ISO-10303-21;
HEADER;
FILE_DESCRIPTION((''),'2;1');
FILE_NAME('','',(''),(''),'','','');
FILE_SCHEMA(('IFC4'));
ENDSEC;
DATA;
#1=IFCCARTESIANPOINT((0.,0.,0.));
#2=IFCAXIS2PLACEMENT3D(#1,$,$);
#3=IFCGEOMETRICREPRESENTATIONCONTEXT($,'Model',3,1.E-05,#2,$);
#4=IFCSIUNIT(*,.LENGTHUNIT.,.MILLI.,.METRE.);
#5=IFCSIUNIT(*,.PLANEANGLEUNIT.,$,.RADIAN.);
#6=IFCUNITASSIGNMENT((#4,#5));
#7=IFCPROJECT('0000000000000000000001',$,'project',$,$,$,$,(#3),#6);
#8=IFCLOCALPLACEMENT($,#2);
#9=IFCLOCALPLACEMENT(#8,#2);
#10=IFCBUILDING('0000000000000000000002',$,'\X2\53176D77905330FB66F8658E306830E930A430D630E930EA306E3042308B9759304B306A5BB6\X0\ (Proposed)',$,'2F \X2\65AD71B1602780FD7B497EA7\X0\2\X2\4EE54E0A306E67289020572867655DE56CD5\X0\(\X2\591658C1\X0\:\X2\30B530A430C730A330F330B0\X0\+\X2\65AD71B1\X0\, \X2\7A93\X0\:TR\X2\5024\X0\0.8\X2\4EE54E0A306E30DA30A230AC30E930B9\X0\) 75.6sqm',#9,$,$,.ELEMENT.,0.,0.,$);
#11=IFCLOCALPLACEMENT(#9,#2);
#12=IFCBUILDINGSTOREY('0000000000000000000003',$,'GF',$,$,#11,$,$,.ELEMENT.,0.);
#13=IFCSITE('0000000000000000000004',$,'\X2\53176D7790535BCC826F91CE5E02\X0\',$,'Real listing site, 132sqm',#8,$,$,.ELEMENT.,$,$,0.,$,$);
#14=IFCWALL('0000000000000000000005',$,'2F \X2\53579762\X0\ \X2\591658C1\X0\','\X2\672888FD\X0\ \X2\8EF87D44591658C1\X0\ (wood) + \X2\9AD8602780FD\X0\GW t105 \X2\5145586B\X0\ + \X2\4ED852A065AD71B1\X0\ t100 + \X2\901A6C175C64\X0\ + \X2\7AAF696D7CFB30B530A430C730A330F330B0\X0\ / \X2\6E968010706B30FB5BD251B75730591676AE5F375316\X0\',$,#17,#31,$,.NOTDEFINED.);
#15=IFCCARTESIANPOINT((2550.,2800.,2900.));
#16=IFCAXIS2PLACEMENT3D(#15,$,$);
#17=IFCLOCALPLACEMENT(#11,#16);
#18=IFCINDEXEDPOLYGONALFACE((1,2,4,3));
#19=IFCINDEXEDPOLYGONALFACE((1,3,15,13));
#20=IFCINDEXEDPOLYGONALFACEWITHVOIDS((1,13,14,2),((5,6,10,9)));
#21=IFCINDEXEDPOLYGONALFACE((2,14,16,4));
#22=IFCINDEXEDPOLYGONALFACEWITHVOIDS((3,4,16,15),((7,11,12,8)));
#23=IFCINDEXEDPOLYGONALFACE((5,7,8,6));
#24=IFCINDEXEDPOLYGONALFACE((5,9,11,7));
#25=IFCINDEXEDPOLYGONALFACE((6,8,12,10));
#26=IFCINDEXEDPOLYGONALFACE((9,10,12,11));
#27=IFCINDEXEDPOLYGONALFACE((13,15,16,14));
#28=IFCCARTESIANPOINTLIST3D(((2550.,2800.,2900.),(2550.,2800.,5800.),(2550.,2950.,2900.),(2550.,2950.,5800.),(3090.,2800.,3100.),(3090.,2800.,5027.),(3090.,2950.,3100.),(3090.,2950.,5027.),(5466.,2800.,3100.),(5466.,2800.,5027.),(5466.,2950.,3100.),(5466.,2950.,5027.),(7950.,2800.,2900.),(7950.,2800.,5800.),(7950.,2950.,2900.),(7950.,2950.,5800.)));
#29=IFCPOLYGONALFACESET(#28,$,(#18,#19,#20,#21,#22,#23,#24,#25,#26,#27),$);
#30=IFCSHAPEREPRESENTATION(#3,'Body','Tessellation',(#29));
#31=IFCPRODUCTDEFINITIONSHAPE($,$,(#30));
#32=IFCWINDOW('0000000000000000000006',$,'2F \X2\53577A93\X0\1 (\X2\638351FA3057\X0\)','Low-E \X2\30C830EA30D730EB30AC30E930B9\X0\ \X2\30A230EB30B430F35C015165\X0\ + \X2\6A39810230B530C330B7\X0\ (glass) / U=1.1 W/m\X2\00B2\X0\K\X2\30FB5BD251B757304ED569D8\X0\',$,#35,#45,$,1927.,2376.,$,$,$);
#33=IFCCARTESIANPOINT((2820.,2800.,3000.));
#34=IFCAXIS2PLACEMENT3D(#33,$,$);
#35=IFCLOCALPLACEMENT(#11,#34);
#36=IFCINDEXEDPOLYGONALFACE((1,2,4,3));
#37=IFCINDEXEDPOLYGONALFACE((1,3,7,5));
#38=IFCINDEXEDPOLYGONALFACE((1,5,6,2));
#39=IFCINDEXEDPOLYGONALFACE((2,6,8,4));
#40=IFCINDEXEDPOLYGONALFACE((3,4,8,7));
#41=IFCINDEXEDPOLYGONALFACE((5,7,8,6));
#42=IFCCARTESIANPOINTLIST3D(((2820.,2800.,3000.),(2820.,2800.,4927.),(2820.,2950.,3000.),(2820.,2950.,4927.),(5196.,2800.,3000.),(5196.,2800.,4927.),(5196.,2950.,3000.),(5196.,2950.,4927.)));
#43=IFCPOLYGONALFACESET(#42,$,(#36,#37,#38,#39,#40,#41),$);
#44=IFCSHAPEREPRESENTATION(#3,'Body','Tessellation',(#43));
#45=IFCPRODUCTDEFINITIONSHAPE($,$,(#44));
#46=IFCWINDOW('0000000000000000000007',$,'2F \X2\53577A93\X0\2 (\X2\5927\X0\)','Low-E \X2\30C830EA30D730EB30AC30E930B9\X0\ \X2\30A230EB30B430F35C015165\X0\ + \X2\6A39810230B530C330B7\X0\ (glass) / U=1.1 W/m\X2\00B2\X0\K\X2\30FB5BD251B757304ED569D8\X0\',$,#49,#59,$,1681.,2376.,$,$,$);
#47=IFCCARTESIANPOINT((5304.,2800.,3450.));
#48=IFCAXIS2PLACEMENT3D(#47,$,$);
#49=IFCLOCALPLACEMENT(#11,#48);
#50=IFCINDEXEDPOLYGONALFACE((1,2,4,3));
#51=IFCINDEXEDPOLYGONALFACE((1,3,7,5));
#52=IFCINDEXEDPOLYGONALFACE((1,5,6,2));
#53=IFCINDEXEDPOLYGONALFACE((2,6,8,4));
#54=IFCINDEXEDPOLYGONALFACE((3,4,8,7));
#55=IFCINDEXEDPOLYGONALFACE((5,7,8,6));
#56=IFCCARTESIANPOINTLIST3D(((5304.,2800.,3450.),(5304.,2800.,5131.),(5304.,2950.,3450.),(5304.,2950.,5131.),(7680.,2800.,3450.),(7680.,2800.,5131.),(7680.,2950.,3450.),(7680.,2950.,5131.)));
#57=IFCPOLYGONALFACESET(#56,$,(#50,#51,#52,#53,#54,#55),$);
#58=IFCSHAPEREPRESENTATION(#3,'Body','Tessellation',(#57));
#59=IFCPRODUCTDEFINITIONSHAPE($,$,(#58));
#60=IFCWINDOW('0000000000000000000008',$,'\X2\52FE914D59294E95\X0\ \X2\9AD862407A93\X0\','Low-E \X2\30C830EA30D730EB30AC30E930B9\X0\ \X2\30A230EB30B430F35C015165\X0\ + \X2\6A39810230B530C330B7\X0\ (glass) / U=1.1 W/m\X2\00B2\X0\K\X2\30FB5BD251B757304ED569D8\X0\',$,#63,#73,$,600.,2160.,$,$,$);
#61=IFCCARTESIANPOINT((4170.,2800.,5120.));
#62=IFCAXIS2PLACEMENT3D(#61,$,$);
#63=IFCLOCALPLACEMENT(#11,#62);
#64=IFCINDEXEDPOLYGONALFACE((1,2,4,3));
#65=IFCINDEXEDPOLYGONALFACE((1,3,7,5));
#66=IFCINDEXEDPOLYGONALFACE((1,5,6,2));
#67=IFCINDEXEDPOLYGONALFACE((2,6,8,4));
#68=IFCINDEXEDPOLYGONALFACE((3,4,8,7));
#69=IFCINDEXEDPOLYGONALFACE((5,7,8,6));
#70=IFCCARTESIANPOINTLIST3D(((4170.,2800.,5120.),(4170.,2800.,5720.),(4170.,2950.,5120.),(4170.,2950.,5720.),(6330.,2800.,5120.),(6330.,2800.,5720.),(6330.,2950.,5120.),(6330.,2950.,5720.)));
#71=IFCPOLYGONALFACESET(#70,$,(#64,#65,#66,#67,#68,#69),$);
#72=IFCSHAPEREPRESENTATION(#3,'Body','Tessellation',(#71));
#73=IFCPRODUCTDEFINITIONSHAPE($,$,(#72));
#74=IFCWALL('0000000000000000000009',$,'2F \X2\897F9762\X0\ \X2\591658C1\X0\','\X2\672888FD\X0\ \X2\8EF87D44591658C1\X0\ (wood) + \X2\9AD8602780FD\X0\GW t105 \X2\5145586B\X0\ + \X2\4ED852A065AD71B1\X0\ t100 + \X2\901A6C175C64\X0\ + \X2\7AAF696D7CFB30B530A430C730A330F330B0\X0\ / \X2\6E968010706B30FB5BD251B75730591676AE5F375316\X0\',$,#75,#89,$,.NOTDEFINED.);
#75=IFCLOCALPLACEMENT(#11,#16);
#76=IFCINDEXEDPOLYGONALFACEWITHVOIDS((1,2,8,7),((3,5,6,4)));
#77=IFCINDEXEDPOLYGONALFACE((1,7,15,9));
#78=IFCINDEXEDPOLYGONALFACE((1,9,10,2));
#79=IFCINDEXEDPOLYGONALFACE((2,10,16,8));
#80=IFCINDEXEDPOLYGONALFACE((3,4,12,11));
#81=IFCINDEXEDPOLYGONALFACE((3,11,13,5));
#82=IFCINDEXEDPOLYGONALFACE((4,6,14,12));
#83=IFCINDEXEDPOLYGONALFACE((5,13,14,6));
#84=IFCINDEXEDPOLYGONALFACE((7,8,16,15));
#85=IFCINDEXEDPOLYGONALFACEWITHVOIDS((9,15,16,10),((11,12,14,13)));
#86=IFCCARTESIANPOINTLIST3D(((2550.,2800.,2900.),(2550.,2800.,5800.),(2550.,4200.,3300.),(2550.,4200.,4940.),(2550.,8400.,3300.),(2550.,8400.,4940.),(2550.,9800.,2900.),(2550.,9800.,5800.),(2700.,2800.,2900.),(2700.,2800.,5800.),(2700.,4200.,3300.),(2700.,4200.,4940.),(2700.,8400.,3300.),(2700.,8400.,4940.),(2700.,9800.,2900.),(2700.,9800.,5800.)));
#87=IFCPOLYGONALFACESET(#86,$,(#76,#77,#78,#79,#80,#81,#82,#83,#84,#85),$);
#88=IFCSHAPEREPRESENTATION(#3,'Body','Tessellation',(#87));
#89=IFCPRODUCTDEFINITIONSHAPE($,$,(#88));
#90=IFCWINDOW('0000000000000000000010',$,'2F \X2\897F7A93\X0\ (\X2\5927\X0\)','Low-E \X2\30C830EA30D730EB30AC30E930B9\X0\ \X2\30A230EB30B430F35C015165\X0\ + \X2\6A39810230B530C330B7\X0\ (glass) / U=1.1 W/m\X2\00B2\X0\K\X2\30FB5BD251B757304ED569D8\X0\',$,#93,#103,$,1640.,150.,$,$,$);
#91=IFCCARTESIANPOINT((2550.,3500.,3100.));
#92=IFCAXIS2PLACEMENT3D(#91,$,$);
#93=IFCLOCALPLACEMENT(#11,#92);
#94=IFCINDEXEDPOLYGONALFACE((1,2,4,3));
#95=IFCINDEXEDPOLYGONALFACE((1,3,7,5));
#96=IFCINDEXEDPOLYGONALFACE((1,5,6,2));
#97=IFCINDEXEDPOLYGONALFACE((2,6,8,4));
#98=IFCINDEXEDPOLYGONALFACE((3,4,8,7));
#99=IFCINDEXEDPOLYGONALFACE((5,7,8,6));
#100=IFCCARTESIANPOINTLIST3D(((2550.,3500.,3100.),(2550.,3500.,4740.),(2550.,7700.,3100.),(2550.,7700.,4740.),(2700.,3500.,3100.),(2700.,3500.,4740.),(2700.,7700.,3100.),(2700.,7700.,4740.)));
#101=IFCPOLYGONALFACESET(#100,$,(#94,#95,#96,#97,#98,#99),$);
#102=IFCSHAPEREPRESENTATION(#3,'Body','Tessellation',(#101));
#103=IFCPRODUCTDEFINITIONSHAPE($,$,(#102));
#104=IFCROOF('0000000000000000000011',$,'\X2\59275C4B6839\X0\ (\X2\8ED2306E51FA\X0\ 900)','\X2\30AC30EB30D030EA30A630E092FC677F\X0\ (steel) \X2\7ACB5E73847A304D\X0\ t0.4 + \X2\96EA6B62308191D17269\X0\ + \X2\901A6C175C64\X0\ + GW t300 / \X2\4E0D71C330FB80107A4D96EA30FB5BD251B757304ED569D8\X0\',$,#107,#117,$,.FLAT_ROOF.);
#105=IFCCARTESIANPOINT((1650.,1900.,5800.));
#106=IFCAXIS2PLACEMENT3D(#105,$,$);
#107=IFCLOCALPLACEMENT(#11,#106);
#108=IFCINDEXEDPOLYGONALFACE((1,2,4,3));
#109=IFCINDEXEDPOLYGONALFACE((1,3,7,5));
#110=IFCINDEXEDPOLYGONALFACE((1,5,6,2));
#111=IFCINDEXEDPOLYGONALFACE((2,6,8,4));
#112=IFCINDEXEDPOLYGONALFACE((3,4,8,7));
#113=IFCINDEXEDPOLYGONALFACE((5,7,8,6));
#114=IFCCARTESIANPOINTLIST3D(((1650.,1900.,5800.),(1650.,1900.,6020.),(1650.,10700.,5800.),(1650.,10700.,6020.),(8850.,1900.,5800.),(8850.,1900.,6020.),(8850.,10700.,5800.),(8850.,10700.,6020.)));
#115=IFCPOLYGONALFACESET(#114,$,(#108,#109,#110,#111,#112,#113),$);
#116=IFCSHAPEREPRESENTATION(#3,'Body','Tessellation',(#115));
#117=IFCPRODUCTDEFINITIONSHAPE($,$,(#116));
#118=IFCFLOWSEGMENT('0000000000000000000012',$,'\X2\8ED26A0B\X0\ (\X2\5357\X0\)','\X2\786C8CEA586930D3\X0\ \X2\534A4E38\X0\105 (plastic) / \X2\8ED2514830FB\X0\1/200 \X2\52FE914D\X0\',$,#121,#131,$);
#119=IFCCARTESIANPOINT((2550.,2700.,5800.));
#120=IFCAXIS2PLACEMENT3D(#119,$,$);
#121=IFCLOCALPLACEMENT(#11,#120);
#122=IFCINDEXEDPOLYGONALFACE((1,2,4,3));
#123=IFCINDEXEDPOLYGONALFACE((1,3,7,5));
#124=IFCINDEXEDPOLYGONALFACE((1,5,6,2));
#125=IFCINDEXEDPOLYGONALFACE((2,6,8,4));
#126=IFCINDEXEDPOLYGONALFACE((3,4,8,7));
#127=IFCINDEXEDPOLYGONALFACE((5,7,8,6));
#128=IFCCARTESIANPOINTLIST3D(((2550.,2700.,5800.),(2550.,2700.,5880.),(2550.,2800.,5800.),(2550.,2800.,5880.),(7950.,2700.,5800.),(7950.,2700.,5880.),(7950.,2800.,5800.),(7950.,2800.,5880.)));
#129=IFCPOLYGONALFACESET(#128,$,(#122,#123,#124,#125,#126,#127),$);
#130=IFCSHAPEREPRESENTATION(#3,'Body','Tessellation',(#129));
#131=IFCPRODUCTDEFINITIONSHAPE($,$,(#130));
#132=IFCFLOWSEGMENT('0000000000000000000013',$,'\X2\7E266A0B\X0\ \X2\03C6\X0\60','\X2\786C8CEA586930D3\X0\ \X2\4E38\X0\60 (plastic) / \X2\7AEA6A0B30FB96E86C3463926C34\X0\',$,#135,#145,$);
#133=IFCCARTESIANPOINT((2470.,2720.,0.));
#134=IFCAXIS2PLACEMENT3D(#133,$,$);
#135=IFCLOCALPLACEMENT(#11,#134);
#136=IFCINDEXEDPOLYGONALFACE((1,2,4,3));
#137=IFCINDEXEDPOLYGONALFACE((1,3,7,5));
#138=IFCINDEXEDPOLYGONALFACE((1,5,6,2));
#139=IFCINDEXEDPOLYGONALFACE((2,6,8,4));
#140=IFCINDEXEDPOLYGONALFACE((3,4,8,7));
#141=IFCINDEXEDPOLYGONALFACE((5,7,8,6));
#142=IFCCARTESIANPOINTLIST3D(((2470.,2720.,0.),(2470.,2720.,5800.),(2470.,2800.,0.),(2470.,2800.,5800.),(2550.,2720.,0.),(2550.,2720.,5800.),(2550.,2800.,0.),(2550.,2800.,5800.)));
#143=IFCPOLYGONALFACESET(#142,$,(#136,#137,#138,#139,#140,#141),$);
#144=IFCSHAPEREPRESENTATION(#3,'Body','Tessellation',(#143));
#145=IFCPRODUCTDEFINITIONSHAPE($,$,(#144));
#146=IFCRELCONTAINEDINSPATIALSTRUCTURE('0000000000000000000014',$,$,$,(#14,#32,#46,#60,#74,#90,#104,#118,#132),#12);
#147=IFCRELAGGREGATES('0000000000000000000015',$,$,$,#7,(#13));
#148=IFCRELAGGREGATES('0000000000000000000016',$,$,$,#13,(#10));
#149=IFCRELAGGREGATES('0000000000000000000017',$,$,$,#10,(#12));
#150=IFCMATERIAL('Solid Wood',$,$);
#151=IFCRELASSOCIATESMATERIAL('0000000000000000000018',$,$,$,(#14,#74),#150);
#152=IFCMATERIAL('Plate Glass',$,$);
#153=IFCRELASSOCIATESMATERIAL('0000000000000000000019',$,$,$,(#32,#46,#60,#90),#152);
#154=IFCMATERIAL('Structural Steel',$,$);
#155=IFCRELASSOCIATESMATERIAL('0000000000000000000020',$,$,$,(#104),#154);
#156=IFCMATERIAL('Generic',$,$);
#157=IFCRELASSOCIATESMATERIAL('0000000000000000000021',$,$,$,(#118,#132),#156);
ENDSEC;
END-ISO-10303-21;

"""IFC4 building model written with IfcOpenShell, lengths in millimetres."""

from ifc_helpers import new_model, si_unit, frame, frame_2d, origin, place, context, project, spatial, rectangle, extrude, material, element, fill, save


model = new_model("IFC4")

# Units and contexts
model_context = context("Model", 3, precision=1e-05, world=origin())
ifc_project = project(units=[si_unit("LENGTHUNIT", "METRE", prefix="MILLI"), si_unit("PLANEANGLEUNIT", "RADIAN")], contexts=[model_context])

# Site, building, storey
site_placement = place(None, origin())
site = spatial("IfcSite", under=ifc_project, at=site_placement, Name="北海道富良野市", ObjectType="Real listing site, 132sqm", CompositionType="ELEMENT", RefElevation=0.0)
building_placement = place(site_placement, origin())
building = spatial("IfcBuilding", under=site, at=building_placement, Name="北海道・書斎とライブラリのある静かな家 (Proposed)", ObjectType="2F 断熱性能等级2以上の木造在来工法(外壁:サイディング+断熱, 窓:TR値0.8以上のペアガラス) 75.6sqm", CompositionType="ELEMENT", ElevationOfRefHeight=0.0, ElevationOfTerrain=0.0)
storey_placement = place(building_placement, origin())
storey = spatial("IfcBuildingStorey", under=building, at=storey_placement, Name="GF", CompositionType="ELEMENT", Elevation=0.0)

# Shared definitions
ifc_material_1 = material(Name="Solid Wood")

# Shared definitions
ifc_material_2 = material(Name="Plate Glass")

# Wall, openings, windows
wall_1_placement = place(storey_placement, frame((2550.0, 2800.0, 2900.0)))
wall_1 = element("IfcWall", 1, at=wall_1_placement, inside=storey, material=ifc_material_1, Name="2F 南面 外壁", Description="木製 軸組外壁 (wood) + 高性能GW t105 充填 + 付加断熱 t100 + 通気層 + 窯業系サイディング / 準耐火・寒冷地外皮強化", PredefinedType="NOTDEFINED", context=model_context, shape_type="SweptSolid", body=[
    extrude(rectangle(XDim=5400.0, YDim=150.0, at=frame_2d((2700.0, 75.0))), frame((2550.0, 2800.0, 2900.0)), (0.0, 0.0, 1.0), 2900.0),
])
opening_1_placement = place(storey_placement, frame((2820.0, 2800.0, 3000.0)))
opening_1 = element("IfcOpeningElement", 2, at=opening_1_placement, cuts=wall_1, PredefinedType="NOTDEFINED", context=model_context, shape_type="SweptSolid", body=[
    extrude(rectangle(XDim=2376.0, YDim=150.0, at=frame_2d((1188.0, 75.0))), frame((2820.0, 2800.0, 3000.0)), (0.0, 0.0, 1.0), 1927.0),
])
opening_2_placement = place(storey_placement, frame((5304.0, 2800.0, 3450.0)))
opening_2 = element("IfcOpeningElement", 3, at=opening_2_placement, cuts=wall_1, PredefinedType="NOTDEFINED", context=model_context, shape_type="SweptSolid", body=[
    extrude(rectangle(XDim=2376.0, YDim=150.0, at=frame_2d((1188.0, 75.0))), frame((5304.0, 2800.0, 3450.0)), (0.0, 0.0, 1.0), 1681.0),
])
opening_3_placement = place(storey_placement, frame((4170.0, 2800.0, 5120.0)))
opening_3 = element("IfcOpeningElement", 4, at=opening_3_placement, cuts=wall_1, PredefinedType="NOTDEFINED", context=model_context, shape_type="SweptSolid", body=[
    extrude(rectangle(XDim=2160.0, YDim=150.0, at=frame_2d((1080.0, 75.0))), frame((4170.0, 2800.0, 5120.0)), (0.0, 0.0, 1.0), 600.0),
])
window_1_placement = place(storey_placement, frame((2820.0, 2800.0, 3000.0)))
window_1 = element("IfcWindow", 5, at=window_1_placement, inside=storey, material=ifc_material_2, Name="2F 南窓1 (掃出し)", Description="Low-E トリプルガラス アルゴン封入 + 樹脂サッシ (glass) / U=1.1 W/m²K・寒冷地仕様", OverallHeight=1927.0, OverallWidth=2376.0, context=model_context, shape_type="SweptSolid", body=[
    extrude(rectangle(XDim=2376.0, YDim=150.0, at=frame_2d((1188.0, 75.0))), frame((2820.0, 2800.0, 3000.0)), (0.0, 0.0, 1.0), 1927.0),
])
fill(opening_1, window_1)
window_2_placement = place(storey_placement, frame((5304.0, 2800.0, 3450.0)))
window_2 = element("IfcWindow", 6, at=window_2_placement, inside=storey, material=ifc_material_2, Name="2F 南窓2 (大)", Description="Low-E トリプルガラス アルゴン封入 + 樹脂サッシ (glass) / U=1.1 W/m²K・寒冷地仕様", OverallHeight=1681.0, OverallWidth=2376.0, context=model_context, shape_type="SweptSolid", body=[
    extrude(rectangle(XDim=2376.0, YDim=150.0, at=frame_2d((1188.0, 75.0))), frame((5304.0, 2800.0, 3450.0)), (0.0, 0.0, 1.0), 1681.0),
])
fill(opening_2, window_2)
window_3_placement = place(storey_placement, frame((4170.0, 2800.0, 5120.0)))
window_3 = element("IfcWindow", 7, at=window_3_placement, inside=storey, material=ifc_material_2, Name="勾配天井 高所窓", Description="Low-E トリプルガラス アルゴン封入 + 樹脂サッシ (glass) / U=1.1 W/m²K・寒冷地仕様", OverallHeight=600.0, OverallWidth=2160.0, context=model_context, shape_type="SweptSolid", body=[
    extrude(rectangle(XDim=2160.0, YDim=150.0, at=frame_2d((1080.0, 75.0))), frame((4170.0, 2800.0, 5120.0)), (0.0, 0.0, 1.0), 600.0),
])
fill(opening_3, window_3)

# Wall, opening, window
wall_2_placement = place(storey_placement, frame((2550.0, 2800.0, 2900.0)))
wall_2 = element("IfcWall", 8, at=wall_2_placement, inside=storey, material=ifc_material_1, Name="2F 西面 外壁", Description="木製 軸組外壁 (wood) + 高性能GW t105 充填 + 付加断熱 t100 + 通気層 + 窯業系サイディング / 準耐火・寒冷地外皮強化", PredefinedType="NOTDEFINED", context=model_context, shape_type="SweptSolid", body=[
    extrude(rectangle(XDim=150.0, YDim=7000.0, at=frame_2d((75.0, 3500.0))), frame((2550.0, 2800.0, 2900.0)), (0.0, 0.0, 1.0), 2900.0),
])
opening_4_placement = place(storey_placement, frame((2550.0, 3500.0, 3100.0)))
opening_4 = element("IfcOpeningElement", 9, at=opening_4_placement, cuts=wall_2, PredefinedType="NOTDEFINED", context=model_context, shape_type="SweptSolid", body=[
    extrude(rectangle(XDim=150.0, YDim=4200.0, at=frame_2d((75.0, 2100.0))), frame((2550.0, 3500.0, 3100.0)), (0.0, 0.0, 1.0), 1640.0),
])
window_4_placement = place(storey_placement, frame((2550.0, 3500.0, 3100.0)))
window_4 = element("IfcWindow", 10, at=window_4_placement, inside=storey, material=ifc_material_2, Name="2F 西窓 (大)", Description="Low-E トリプルガラス アルゴン封入 + 樹脂サッシ (glass) / U=1.1 W/m²K・寒冷地仕様", OverallHeight=1640.0, OverallWidth=150.0, context=model_context, shape_type="SweptSolid", body=[
    extrude(rectangle(XDim=150.0, YDim=4200.0, at=frame_2d((75.0, 2100.0))), frame((2550.0, 3500.0, 3100.0)), (0.0, 0.0, 1.0), 1640.0),
])
fill(opening_4, window_4)

# Roof
ifc_material_3 = material(Name="Structural Steel")
roof_placement = place(storey_placement, frame((1650.0, 1900.0, 5800.0)))
element("IfcRoof", 11, at=roof_placement, inside=storey, material=ifc_material_3, Name="大屋根 (軒の出 900)", Description="ガルバリウム鋼板 (steel) 立平葺き t0.4 + 雪止め金物 + 通気層 + GW t300 / 不燃・耐積雪・寒冷地仕様", PredefinedType="FLAT_ROOF", context=model_context, shape_type="SweptSolid", body=[
    extrude(rectangle(XDim=7200.0, YDim=8800.0, at=frame_2d((3600.0, 4400.0))), frame((1650.0, 1900.0, 5800.0)), (0.0, 0.0, 1.0), 220.0),
])

# Flow segments
ifc_material_4 = material(Name="Generic")
flow_segment_1_placement = place(storey_placement, frame((2550.0, 2700.0, 5800.0)))
element("IfcFlowSegment", 12, at=flow_segment_1_placement, inside=storey, material=ifc_material_4, Name="軒樋 (南)", Description="硬質塩ビ 半丸105 (plastic) / 軒先・1/200 勾配", context=model_context, shape_type="SweptSolid", body=[
    extrude(rectangle(XDim=5400.0, YDim=100.0, at=frame_2d((2700.0, 50.0))), frame((2550.0, 2700.0, 5800.0)), (0.0, 0.0, 1.0), 80.0),
])
flow_segment_2_placement = place(storey_placement, frame((2470.0, 2720.0, 0.0)))
element("IfcFlowSegment", 13, at=flow_segment_2_placement, inside=storey, material=ifc_material_4, Name="縦樋 φ60", Description="硬質塩ビ 丸60 (plastic) / 竪樋・雨水排水", context=model_context, shape_type="SweptSolid", body=[
    extrude(rectangle(XDim=80.0, YDim=80.0, at=frame_2d((40.0, 40.0))), frame((2470.0, 2720.0, 0.0)), (0.0, 0.0, 1.0), 5800.0),
])

save(model, "model.ifc")
